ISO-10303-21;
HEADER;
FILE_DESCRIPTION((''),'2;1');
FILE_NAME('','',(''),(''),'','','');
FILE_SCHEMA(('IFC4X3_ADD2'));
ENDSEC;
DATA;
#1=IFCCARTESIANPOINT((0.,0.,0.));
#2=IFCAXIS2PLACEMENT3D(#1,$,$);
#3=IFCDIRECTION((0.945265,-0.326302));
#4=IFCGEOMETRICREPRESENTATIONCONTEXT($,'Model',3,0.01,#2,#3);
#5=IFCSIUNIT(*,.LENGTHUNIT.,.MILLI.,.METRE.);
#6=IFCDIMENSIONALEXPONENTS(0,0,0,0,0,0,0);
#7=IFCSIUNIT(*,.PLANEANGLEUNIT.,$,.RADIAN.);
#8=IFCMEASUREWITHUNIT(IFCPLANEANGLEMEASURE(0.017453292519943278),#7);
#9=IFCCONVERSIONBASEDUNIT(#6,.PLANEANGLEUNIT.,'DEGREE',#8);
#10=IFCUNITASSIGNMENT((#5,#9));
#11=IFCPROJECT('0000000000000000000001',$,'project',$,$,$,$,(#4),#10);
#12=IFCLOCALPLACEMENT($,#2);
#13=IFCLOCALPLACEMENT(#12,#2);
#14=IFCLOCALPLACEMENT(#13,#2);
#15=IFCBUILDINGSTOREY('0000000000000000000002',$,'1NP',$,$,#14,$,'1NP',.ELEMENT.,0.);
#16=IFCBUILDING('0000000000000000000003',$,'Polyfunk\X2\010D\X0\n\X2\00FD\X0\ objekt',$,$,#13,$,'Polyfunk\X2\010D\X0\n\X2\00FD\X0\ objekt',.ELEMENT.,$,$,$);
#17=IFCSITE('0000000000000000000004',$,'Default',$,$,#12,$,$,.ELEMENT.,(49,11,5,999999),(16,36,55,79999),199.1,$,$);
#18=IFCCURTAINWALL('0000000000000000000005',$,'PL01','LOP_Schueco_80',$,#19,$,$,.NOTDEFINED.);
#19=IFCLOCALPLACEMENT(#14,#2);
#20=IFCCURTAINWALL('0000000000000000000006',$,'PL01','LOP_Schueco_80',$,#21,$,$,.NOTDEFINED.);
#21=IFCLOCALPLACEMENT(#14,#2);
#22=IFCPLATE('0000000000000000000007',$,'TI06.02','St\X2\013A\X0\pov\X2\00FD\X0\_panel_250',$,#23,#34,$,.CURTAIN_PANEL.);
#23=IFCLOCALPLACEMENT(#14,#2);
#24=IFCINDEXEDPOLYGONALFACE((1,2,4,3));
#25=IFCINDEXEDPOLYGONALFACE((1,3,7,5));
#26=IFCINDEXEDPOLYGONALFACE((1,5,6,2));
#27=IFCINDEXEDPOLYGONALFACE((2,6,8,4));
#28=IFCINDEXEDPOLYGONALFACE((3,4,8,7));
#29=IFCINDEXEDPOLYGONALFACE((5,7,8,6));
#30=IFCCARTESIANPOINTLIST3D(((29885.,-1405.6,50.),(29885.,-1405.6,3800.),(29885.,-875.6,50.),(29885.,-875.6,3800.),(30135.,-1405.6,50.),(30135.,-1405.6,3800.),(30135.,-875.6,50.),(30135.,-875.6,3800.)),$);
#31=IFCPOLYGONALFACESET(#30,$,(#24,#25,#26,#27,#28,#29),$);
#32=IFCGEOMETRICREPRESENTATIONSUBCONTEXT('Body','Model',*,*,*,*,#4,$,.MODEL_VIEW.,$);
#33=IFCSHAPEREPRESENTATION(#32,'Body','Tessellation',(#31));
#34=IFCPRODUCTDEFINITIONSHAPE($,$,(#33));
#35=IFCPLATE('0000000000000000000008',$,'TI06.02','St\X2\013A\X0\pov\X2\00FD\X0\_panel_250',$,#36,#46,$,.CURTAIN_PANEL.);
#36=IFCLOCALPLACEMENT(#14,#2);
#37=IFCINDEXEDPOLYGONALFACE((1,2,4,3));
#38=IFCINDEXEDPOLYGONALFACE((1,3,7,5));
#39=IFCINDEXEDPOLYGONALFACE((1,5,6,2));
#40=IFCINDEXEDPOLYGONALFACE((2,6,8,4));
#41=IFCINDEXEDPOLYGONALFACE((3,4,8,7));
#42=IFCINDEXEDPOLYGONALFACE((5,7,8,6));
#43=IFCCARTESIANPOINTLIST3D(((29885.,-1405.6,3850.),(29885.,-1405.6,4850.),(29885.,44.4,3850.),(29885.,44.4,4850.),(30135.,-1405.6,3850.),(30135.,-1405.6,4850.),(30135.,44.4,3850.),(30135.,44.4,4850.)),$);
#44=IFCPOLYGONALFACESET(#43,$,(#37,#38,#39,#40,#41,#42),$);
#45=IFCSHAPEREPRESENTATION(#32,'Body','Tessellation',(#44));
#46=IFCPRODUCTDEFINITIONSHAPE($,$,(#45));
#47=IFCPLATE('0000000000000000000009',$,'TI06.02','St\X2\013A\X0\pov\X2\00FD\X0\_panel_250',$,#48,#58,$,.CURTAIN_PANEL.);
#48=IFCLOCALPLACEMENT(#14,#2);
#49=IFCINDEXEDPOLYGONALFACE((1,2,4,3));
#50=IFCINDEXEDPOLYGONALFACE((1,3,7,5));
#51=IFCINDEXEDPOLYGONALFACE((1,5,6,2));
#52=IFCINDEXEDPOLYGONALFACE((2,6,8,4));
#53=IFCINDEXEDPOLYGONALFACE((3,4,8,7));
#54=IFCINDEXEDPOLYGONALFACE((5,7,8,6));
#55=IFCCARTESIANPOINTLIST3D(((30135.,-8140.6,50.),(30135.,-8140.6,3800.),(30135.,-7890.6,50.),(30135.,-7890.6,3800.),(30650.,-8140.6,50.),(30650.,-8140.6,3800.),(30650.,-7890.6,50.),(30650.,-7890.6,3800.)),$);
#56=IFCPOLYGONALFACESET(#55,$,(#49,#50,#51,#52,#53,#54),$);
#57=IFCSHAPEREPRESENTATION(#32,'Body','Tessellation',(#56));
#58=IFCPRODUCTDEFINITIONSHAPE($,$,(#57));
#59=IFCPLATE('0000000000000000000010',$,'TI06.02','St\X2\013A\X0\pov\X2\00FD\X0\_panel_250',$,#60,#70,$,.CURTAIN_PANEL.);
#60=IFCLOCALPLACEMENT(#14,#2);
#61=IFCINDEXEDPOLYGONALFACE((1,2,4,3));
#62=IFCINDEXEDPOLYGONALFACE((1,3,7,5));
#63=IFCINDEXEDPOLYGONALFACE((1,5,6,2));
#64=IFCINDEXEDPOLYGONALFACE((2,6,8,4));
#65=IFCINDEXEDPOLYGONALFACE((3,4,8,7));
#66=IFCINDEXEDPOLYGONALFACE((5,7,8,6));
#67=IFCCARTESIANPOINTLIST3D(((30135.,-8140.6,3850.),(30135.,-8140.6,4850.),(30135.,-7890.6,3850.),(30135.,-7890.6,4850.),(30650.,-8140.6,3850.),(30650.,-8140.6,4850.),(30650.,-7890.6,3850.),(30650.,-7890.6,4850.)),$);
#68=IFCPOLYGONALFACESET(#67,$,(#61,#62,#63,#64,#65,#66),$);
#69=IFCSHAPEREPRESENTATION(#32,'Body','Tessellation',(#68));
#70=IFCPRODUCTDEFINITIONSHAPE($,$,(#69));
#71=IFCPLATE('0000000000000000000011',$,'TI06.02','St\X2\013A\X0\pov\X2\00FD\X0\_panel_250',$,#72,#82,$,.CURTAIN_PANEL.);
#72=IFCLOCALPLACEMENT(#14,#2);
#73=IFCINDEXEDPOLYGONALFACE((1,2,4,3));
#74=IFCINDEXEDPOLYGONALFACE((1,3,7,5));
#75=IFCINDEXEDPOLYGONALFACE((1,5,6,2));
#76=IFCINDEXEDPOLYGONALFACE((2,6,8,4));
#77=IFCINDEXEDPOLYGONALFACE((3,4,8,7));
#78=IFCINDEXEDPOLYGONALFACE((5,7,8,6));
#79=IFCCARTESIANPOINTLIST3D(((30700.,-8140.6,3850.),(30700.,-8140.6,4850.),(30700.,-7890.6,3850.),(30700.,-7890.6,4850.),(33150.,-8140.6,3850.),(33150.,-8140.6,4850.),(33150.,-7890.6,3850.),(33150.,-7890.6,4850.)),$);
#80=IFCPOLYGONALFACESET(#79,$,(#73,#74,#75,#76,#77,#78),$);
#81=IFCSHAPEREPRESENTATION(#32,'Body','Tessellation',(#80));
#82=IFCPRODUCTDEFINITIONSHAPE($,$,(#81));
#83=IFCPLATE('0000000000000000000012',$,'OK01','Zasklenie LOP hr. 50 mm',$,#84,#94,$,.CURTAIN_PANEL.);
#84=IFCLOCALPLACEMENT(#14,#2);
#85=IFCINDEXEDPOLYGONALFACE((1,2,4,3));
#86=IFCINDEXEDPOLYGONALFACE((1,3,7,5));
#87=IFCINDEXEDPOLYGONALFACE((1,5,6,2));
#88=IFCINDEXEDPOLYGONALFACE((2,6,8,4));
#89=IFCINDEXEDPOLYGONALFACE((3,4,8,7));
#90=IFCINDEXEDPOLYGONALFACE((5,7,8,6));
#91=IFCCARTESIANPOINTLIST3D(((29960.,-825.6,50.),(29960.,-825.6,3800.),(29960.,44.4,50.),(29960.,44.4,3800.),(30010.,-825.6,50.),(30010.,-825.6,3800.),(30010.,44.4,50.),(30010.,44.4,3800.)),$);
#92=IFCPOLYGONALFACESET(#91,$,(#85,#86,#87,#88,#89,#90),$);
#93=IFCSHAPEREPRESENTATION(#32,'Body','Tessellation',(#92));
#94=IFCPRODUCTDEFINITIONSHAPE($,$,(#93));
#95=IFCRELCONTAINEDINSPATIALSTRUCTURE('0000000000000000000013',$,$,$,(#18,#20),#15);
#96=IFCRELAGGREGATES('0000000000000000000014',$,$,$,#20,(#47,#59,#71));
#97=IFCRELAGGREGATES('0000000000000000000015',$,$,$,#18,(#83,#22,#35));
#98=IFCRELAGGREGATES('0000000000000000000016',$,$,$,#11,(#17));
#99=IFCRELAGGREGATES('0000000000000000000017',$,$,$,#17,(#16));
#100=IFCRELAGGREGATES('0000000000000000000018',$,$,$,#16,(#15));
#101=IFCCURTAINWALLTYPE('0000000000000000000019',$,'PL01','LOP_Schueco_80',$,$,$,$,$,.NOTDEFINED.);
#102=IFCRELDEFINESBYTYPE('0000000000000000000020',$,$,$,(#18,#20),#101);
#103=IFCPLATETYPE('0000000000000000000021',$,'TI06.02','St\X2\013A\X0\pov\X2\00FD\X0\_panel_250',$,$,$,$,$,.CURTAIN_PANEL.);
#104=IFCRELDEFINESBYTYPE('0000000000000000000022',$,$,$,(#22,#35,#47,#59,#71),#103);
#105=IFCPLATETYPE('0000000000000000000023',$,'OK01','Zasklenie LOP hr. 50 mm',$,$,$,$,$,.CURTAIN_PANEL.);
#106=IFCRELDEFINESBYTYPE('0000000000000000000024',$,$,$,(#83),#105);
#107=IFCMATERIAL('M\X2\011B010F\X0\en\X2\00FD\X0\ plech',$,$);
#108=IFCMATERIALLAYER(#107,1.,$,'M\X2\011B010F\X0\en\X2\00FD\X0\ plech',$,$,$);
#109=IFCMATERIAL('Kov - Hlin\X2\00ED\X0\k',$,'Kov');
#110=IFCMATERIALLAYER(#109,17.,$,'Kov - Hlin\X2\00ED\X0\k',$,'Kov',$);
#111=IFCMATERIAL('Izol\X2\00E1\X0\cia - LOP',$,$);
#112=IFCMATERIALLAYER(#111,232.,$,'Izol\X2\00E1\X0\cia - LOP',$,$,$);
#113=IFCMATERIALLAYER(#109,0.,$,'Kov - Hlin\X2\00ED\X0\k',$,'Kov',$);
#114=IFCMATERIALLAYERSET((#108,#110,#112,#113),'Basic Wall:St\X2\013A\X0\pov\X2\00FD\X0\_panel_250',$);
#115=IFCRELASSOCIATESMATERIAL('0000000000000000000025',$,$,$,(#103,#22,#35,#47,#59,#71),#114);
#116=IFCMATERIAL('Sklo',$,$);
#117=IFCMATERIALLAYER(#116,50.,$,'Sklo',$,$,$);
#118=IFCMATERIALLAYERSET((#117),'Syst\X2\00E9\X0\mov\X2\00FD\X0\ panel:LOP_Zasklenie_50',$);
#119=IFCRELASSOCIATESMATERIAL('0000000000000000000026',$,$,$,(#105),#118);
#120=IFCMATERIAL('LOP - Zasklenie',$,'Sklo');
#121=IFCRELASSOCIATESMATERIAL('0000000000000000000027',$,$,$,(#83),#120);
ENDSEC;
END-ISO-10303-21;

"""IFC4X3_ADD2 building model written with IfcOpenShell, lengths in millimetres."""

from ifc_helpers import new_model, entity, si_unit, converted_unit, direction, frame, frame_2d, origin, place, context, subcontext, project, spatial, rectangle, extrude, source, transform, mapped, material, layer, layer_set, layer_usage, type_object, type_shapes, element, aggregate, save


model = new_model("IFC4X3_ADD2")

# Units and contexts
model_context = context("Model", 3, precision=0.01, world=origin(), true_north=direction((0.945265, -0.326302)))
body_context = subcontext(model_context, "Body", "Model", "MODEL_VIEW")
ifc_project = project(units=[si_unit("LENGTHUNIT", "METRE", prefix="MILLI"), converted_unit("PLANEANGLEUNIT", "DEGREE", entity("IfcPlaneAngleMeasure", 0.017453292519943278), si_unit("PLANEANGLEUNIT", "RADIAN"), dimensions=[0, 0, 0, 0, 0, 0, 0])], contexts=[model_context])

# Site, building, storey
site_placement = place(None, origin())
site = spatial("IfcSite", under=ifc_project, at=site_placement, Name="Default", CompositionType="ELEMENT", RefLatitude=(49, 11, 5, 999999), RefLongitude=(16, 36, 55, 79999), RefElevation=199.1)
building_placement = place(site_placement, origin())
building = spatial("IfcBuilding", under=site, at=building_placement, Name="Polyfunkčný objekt", LongName="Polyfunkčný objekt", CompositionType="ELEMENT")
storey_placement = place(building_placement, origin())
storey = spatial("IfcBuildingStorey", under=building, at=storey_placement, Name="1NP", LongName="1NP", CompositionType="ELEMENT", Elevation=0.0)

# Curtain wall
curtain_wall_type = type_object("IfcCurtainWallType", Name="PL01", Description="LOP_Schueco_80", PredefinedType="NOTDEFINED")
curtain_wall_1_placement = place(storey_placement, origin())
curtain_wall_1 = element("IfcCurtainWall", 1, at=curtain_wall_1_placement, inside=storey, type_object=curtain_wall_type, Name="PL01", Description="LOP_Schueco_80", PredefinedType="NOTDEFINED")

# Curtain wall
curtain_wall_2_placement = place(storey_placement, origin())
curtain_wall_2 = element("IfcCurtainWall", 2, at=curtain_wall_2_placement, inside=storey, type_object=curtain_wall_type, Name="PL01", Description="LOP_Schueco_80", PredefinedType="NOTDEFINED")

# Plates
ifc_material_1 = material(Name="Měďený plech")
ifc_layer_1 = layer(ifc_material_1, 1.0, Name="Měďený plech")
ifc_material_2 = material(Name="Kov - Hliník", Category="Kov")
ifc_layer_2 = layer(ifc_material_2, 17.0, Name="Kov - Hliník", Category="Kov")
ifc_material_3 = material(Name="Izolácia - LOP")
ifc_layer_3 = layer(ifc_material_3, 232.0, Name="Izolácia - LOP")
ifc_layer_4 = layer(ifc_material_2, 0.0, Name="Kov - Hliník", Category="Kov")
ifc_layer_set_1 = layer_set([ifc_layer_1, ifc_layer_2, ifc_layer_3, ifc_layer_4], Name="Basic Wall:Stĺpový_panel_250")
ifc_layer_usage_1 = layer_usage(ifc_layer_set_1, "AXIS2", "POSITIVE", -125.0)
plate_type_1 = type_object("IfcPlateType", Name="TI06.02", Description="Stĺpový_panel_250", PredefinedType="CURTAIN_PANEL", material=ifc_layer_set_1)
plate_1_placement = place(storey_placement, frame((30010.0, -875.6, 50.0), z_axis=(0.0, 0.0, 1.0), x_axis=(0.0, -1.0, 0.0)))
plate_1 = element("IfcPlate", 3, at=plate_1_placement, type_object=plate_type_1, material=ifc_layer_usage_1, Name="TI06.02", Description="Stĺpový_panel_250", PredefinedType="CURTAIN_PANEL", context=body_context, shape_type="SweptSolid", body=[
    extrude(rectangle(XDim=250.0, YDim=530.0, at=frame_2d((0.0, 0.0), x_axis=(1.0, 0.0))), frame((265.0, 0.0, 0.0), z_axis=(0.0, 0.0, 1.0), x_axis=(0.0, 1.0, 0.0)), (0.0, 0.0, 1.0), 3750.0),
])
ifc_layer_usage_2 = layer_usage(ifc_layer_set_1, "AXIS2", "POSITIVE", -125.0)
plate_2_placement = place(storey_placement, frame((30010.0, 44.4, 3850.0), z_axis=(0.0, 0.0, 1.0), x_axis=(0.0, -1.0, 0.0)))
plate_2 = element("IfcPlate", 4, at=plate_2_placement, type_object=plate_type_1, material=ifc_layer_usage_2, Name="TI06.02", Description="Stĺpový_panel_250", PredefinedType="CURTAIN_PANEL", context=body_context, shape_type="SweptSolid", body=[
    extrude(rectangle(XDim=250.0, YDim=1450.0, at=frame_2d((0.0, 0.0), x_axis=(1.0, 0.0))), frame((725.0, 0.0, 0.0), z_axis=(0.0, 0.0, 1.0), x_axis=(0.0, 1.0, 0.0)), (0.0, 0.0, 1.0), 1000.0),
])
ifc_layer_usage_3 = layer_usage(ifc_layer_set_1, "AXIS2", "POSITIVE", -125.0)
plate_3_placement = place(storey_placement, frame((30135.0, -8015.6, 50.0)))
plate_3 = element("IfcPlate", 5, at=plate_3_placement, type_object=plate_type_1, material=ifc_layer_usage_3, Name="TI06.02", Description="Stĺpový_panel_250", PredefinedType="CURTAIN_PANEL", context=body_context, shape_type="SweptSolid", body=[
    extrude(rectangle(XDim=250.0, YDim=515.0, at=frame_2d((0.0, 0.0), x_axis=(1.0, 0.0))), frame((257.5, 0.0, 0.0), z_axis=(0.0, 0.0, 1.0), x_axis=(0.0, 1.0, 0.0)), (0.0, 0.0, 1.0), 3750.0),
])
ifc_layer_usage_4 = layer_usage(ifc_layer_set_1, "AXIS2", "POSITIVE", -125.0)
plate_4_placement = place(storey_placement, frame((30135.0, -8015.6, 3850.0)))
plate_4 = element("IfcPlate", 6, at=plate_4_placement, type_object=plate_type_1, material=ifc_layer_usage_4, Name="TI06.02", Description="Stĺpový_panel_250", PredefinedType="CURTAIN_PANEL", context=body_context, shape_type="SweptSolid", body=[
    extrude(rectangle(XDim=250.0, YDim=515.0, at=frame_2d((0.0, 0.0), x_axis=(1.0, 0.0))), frame((257.5, 0.0, 0.0), z_axis=(0.0, 0.0, 1.0), x_axis=(0.0, 1.0, 0.0)), (0.0, 0.0, 1.0), 1000.0),
])
ifc_layer_usage_5 = layer_usage(ifc_layer_set_1, "AXIS2", "POSITIVE", -125.0)
plate_5_placement = place(storey_placement, frame((30700.0, -8015.6, 3850.0)))
plate_5 = element("IfcPlate", 7, at=plate_5_placement, type_object=plate_type_1, material=ifc_layer_usage_5, Name="TI06.02", Description="Stĺpový_panel_250", PredefinedType="CURTAIN_PANEL", context=body_context, shape_type="SweptSolid", body=[
    extrude(rectangle(XDim=250.0, YDim=2450.0, at=frame_2d((0.0, 0.0), x_axis=(1.0, 0.0))), frame((1225.0, 0.0, 0.0), z_axis=(0.0, 0.0, 1.0), x_axis=(0.0, 1.0, 0.0)), (0.0, 0.0, 1.0), 1000.0),
])
aggregate(curtain_wall_2, [plate_3, plate_4, plate_5])
ifc_material_4 = material(Name="LOP - Zasklenie", Category="Sklo")
ifc_material_5 = material(Name="Sklo")
ifc_layer_5 = layer(ifc_material_5, 50.0, Name="Sklo")
ifc_layer_set_2 = layer_set([ifc_layer_5], Name="Systémový panel:LOP_Zasklenie_50")
plate_type_2 = type_object("IfcPlateType", Name="OK01", Description="Zasklenie LOP hr. 50 mm", PredefinedType="CURTAIN_PANEL", material=ifc_layer_set_2)
shared_shape_1 = source(origin(), body_context, "Body", "SweptSolid", [
    extrude(rectangle(XDim=3750.0, YDim=870.0, at=frame_2d((-141.7, 0.0), x_axis=(1.0, 0.0))), frame((0.0, -50.0, 2016.7), z_axis=(0.0, 1.0, 0.0), x_axis=(0.0, 0.0, 1.0)), (0.0, 0.0, 1.0), 50.0),
])
type_shapes(plate_type_2, [shared_shape_1])
plate_6_placement = place(curtain_wall_1_placement, frame((30010.0, -390.6, 50.0), z_axis=(0.0, 0.0, 1.0), x_axis=(0.0, -1.0, 0.0)))
plate_6 = element("IfcPlate", 8, at=plate_6_placement, type_object=plate_type_2, material=ifc_material_4, Name="OK01", Description="Zasklenie LOP hr. 50 mm", PredefinedType="CURTAIN_PANEL", context=body_context, shape_type="MappedRepresentation", body=[
    mapped(shared_shape_1, transform((0.0, 0.0, 0.0), scale=1.0)),
])
aggregate(curtain_wall_1, [plate_6, plate_1, plate_2])

save(model, "model.ifc")
